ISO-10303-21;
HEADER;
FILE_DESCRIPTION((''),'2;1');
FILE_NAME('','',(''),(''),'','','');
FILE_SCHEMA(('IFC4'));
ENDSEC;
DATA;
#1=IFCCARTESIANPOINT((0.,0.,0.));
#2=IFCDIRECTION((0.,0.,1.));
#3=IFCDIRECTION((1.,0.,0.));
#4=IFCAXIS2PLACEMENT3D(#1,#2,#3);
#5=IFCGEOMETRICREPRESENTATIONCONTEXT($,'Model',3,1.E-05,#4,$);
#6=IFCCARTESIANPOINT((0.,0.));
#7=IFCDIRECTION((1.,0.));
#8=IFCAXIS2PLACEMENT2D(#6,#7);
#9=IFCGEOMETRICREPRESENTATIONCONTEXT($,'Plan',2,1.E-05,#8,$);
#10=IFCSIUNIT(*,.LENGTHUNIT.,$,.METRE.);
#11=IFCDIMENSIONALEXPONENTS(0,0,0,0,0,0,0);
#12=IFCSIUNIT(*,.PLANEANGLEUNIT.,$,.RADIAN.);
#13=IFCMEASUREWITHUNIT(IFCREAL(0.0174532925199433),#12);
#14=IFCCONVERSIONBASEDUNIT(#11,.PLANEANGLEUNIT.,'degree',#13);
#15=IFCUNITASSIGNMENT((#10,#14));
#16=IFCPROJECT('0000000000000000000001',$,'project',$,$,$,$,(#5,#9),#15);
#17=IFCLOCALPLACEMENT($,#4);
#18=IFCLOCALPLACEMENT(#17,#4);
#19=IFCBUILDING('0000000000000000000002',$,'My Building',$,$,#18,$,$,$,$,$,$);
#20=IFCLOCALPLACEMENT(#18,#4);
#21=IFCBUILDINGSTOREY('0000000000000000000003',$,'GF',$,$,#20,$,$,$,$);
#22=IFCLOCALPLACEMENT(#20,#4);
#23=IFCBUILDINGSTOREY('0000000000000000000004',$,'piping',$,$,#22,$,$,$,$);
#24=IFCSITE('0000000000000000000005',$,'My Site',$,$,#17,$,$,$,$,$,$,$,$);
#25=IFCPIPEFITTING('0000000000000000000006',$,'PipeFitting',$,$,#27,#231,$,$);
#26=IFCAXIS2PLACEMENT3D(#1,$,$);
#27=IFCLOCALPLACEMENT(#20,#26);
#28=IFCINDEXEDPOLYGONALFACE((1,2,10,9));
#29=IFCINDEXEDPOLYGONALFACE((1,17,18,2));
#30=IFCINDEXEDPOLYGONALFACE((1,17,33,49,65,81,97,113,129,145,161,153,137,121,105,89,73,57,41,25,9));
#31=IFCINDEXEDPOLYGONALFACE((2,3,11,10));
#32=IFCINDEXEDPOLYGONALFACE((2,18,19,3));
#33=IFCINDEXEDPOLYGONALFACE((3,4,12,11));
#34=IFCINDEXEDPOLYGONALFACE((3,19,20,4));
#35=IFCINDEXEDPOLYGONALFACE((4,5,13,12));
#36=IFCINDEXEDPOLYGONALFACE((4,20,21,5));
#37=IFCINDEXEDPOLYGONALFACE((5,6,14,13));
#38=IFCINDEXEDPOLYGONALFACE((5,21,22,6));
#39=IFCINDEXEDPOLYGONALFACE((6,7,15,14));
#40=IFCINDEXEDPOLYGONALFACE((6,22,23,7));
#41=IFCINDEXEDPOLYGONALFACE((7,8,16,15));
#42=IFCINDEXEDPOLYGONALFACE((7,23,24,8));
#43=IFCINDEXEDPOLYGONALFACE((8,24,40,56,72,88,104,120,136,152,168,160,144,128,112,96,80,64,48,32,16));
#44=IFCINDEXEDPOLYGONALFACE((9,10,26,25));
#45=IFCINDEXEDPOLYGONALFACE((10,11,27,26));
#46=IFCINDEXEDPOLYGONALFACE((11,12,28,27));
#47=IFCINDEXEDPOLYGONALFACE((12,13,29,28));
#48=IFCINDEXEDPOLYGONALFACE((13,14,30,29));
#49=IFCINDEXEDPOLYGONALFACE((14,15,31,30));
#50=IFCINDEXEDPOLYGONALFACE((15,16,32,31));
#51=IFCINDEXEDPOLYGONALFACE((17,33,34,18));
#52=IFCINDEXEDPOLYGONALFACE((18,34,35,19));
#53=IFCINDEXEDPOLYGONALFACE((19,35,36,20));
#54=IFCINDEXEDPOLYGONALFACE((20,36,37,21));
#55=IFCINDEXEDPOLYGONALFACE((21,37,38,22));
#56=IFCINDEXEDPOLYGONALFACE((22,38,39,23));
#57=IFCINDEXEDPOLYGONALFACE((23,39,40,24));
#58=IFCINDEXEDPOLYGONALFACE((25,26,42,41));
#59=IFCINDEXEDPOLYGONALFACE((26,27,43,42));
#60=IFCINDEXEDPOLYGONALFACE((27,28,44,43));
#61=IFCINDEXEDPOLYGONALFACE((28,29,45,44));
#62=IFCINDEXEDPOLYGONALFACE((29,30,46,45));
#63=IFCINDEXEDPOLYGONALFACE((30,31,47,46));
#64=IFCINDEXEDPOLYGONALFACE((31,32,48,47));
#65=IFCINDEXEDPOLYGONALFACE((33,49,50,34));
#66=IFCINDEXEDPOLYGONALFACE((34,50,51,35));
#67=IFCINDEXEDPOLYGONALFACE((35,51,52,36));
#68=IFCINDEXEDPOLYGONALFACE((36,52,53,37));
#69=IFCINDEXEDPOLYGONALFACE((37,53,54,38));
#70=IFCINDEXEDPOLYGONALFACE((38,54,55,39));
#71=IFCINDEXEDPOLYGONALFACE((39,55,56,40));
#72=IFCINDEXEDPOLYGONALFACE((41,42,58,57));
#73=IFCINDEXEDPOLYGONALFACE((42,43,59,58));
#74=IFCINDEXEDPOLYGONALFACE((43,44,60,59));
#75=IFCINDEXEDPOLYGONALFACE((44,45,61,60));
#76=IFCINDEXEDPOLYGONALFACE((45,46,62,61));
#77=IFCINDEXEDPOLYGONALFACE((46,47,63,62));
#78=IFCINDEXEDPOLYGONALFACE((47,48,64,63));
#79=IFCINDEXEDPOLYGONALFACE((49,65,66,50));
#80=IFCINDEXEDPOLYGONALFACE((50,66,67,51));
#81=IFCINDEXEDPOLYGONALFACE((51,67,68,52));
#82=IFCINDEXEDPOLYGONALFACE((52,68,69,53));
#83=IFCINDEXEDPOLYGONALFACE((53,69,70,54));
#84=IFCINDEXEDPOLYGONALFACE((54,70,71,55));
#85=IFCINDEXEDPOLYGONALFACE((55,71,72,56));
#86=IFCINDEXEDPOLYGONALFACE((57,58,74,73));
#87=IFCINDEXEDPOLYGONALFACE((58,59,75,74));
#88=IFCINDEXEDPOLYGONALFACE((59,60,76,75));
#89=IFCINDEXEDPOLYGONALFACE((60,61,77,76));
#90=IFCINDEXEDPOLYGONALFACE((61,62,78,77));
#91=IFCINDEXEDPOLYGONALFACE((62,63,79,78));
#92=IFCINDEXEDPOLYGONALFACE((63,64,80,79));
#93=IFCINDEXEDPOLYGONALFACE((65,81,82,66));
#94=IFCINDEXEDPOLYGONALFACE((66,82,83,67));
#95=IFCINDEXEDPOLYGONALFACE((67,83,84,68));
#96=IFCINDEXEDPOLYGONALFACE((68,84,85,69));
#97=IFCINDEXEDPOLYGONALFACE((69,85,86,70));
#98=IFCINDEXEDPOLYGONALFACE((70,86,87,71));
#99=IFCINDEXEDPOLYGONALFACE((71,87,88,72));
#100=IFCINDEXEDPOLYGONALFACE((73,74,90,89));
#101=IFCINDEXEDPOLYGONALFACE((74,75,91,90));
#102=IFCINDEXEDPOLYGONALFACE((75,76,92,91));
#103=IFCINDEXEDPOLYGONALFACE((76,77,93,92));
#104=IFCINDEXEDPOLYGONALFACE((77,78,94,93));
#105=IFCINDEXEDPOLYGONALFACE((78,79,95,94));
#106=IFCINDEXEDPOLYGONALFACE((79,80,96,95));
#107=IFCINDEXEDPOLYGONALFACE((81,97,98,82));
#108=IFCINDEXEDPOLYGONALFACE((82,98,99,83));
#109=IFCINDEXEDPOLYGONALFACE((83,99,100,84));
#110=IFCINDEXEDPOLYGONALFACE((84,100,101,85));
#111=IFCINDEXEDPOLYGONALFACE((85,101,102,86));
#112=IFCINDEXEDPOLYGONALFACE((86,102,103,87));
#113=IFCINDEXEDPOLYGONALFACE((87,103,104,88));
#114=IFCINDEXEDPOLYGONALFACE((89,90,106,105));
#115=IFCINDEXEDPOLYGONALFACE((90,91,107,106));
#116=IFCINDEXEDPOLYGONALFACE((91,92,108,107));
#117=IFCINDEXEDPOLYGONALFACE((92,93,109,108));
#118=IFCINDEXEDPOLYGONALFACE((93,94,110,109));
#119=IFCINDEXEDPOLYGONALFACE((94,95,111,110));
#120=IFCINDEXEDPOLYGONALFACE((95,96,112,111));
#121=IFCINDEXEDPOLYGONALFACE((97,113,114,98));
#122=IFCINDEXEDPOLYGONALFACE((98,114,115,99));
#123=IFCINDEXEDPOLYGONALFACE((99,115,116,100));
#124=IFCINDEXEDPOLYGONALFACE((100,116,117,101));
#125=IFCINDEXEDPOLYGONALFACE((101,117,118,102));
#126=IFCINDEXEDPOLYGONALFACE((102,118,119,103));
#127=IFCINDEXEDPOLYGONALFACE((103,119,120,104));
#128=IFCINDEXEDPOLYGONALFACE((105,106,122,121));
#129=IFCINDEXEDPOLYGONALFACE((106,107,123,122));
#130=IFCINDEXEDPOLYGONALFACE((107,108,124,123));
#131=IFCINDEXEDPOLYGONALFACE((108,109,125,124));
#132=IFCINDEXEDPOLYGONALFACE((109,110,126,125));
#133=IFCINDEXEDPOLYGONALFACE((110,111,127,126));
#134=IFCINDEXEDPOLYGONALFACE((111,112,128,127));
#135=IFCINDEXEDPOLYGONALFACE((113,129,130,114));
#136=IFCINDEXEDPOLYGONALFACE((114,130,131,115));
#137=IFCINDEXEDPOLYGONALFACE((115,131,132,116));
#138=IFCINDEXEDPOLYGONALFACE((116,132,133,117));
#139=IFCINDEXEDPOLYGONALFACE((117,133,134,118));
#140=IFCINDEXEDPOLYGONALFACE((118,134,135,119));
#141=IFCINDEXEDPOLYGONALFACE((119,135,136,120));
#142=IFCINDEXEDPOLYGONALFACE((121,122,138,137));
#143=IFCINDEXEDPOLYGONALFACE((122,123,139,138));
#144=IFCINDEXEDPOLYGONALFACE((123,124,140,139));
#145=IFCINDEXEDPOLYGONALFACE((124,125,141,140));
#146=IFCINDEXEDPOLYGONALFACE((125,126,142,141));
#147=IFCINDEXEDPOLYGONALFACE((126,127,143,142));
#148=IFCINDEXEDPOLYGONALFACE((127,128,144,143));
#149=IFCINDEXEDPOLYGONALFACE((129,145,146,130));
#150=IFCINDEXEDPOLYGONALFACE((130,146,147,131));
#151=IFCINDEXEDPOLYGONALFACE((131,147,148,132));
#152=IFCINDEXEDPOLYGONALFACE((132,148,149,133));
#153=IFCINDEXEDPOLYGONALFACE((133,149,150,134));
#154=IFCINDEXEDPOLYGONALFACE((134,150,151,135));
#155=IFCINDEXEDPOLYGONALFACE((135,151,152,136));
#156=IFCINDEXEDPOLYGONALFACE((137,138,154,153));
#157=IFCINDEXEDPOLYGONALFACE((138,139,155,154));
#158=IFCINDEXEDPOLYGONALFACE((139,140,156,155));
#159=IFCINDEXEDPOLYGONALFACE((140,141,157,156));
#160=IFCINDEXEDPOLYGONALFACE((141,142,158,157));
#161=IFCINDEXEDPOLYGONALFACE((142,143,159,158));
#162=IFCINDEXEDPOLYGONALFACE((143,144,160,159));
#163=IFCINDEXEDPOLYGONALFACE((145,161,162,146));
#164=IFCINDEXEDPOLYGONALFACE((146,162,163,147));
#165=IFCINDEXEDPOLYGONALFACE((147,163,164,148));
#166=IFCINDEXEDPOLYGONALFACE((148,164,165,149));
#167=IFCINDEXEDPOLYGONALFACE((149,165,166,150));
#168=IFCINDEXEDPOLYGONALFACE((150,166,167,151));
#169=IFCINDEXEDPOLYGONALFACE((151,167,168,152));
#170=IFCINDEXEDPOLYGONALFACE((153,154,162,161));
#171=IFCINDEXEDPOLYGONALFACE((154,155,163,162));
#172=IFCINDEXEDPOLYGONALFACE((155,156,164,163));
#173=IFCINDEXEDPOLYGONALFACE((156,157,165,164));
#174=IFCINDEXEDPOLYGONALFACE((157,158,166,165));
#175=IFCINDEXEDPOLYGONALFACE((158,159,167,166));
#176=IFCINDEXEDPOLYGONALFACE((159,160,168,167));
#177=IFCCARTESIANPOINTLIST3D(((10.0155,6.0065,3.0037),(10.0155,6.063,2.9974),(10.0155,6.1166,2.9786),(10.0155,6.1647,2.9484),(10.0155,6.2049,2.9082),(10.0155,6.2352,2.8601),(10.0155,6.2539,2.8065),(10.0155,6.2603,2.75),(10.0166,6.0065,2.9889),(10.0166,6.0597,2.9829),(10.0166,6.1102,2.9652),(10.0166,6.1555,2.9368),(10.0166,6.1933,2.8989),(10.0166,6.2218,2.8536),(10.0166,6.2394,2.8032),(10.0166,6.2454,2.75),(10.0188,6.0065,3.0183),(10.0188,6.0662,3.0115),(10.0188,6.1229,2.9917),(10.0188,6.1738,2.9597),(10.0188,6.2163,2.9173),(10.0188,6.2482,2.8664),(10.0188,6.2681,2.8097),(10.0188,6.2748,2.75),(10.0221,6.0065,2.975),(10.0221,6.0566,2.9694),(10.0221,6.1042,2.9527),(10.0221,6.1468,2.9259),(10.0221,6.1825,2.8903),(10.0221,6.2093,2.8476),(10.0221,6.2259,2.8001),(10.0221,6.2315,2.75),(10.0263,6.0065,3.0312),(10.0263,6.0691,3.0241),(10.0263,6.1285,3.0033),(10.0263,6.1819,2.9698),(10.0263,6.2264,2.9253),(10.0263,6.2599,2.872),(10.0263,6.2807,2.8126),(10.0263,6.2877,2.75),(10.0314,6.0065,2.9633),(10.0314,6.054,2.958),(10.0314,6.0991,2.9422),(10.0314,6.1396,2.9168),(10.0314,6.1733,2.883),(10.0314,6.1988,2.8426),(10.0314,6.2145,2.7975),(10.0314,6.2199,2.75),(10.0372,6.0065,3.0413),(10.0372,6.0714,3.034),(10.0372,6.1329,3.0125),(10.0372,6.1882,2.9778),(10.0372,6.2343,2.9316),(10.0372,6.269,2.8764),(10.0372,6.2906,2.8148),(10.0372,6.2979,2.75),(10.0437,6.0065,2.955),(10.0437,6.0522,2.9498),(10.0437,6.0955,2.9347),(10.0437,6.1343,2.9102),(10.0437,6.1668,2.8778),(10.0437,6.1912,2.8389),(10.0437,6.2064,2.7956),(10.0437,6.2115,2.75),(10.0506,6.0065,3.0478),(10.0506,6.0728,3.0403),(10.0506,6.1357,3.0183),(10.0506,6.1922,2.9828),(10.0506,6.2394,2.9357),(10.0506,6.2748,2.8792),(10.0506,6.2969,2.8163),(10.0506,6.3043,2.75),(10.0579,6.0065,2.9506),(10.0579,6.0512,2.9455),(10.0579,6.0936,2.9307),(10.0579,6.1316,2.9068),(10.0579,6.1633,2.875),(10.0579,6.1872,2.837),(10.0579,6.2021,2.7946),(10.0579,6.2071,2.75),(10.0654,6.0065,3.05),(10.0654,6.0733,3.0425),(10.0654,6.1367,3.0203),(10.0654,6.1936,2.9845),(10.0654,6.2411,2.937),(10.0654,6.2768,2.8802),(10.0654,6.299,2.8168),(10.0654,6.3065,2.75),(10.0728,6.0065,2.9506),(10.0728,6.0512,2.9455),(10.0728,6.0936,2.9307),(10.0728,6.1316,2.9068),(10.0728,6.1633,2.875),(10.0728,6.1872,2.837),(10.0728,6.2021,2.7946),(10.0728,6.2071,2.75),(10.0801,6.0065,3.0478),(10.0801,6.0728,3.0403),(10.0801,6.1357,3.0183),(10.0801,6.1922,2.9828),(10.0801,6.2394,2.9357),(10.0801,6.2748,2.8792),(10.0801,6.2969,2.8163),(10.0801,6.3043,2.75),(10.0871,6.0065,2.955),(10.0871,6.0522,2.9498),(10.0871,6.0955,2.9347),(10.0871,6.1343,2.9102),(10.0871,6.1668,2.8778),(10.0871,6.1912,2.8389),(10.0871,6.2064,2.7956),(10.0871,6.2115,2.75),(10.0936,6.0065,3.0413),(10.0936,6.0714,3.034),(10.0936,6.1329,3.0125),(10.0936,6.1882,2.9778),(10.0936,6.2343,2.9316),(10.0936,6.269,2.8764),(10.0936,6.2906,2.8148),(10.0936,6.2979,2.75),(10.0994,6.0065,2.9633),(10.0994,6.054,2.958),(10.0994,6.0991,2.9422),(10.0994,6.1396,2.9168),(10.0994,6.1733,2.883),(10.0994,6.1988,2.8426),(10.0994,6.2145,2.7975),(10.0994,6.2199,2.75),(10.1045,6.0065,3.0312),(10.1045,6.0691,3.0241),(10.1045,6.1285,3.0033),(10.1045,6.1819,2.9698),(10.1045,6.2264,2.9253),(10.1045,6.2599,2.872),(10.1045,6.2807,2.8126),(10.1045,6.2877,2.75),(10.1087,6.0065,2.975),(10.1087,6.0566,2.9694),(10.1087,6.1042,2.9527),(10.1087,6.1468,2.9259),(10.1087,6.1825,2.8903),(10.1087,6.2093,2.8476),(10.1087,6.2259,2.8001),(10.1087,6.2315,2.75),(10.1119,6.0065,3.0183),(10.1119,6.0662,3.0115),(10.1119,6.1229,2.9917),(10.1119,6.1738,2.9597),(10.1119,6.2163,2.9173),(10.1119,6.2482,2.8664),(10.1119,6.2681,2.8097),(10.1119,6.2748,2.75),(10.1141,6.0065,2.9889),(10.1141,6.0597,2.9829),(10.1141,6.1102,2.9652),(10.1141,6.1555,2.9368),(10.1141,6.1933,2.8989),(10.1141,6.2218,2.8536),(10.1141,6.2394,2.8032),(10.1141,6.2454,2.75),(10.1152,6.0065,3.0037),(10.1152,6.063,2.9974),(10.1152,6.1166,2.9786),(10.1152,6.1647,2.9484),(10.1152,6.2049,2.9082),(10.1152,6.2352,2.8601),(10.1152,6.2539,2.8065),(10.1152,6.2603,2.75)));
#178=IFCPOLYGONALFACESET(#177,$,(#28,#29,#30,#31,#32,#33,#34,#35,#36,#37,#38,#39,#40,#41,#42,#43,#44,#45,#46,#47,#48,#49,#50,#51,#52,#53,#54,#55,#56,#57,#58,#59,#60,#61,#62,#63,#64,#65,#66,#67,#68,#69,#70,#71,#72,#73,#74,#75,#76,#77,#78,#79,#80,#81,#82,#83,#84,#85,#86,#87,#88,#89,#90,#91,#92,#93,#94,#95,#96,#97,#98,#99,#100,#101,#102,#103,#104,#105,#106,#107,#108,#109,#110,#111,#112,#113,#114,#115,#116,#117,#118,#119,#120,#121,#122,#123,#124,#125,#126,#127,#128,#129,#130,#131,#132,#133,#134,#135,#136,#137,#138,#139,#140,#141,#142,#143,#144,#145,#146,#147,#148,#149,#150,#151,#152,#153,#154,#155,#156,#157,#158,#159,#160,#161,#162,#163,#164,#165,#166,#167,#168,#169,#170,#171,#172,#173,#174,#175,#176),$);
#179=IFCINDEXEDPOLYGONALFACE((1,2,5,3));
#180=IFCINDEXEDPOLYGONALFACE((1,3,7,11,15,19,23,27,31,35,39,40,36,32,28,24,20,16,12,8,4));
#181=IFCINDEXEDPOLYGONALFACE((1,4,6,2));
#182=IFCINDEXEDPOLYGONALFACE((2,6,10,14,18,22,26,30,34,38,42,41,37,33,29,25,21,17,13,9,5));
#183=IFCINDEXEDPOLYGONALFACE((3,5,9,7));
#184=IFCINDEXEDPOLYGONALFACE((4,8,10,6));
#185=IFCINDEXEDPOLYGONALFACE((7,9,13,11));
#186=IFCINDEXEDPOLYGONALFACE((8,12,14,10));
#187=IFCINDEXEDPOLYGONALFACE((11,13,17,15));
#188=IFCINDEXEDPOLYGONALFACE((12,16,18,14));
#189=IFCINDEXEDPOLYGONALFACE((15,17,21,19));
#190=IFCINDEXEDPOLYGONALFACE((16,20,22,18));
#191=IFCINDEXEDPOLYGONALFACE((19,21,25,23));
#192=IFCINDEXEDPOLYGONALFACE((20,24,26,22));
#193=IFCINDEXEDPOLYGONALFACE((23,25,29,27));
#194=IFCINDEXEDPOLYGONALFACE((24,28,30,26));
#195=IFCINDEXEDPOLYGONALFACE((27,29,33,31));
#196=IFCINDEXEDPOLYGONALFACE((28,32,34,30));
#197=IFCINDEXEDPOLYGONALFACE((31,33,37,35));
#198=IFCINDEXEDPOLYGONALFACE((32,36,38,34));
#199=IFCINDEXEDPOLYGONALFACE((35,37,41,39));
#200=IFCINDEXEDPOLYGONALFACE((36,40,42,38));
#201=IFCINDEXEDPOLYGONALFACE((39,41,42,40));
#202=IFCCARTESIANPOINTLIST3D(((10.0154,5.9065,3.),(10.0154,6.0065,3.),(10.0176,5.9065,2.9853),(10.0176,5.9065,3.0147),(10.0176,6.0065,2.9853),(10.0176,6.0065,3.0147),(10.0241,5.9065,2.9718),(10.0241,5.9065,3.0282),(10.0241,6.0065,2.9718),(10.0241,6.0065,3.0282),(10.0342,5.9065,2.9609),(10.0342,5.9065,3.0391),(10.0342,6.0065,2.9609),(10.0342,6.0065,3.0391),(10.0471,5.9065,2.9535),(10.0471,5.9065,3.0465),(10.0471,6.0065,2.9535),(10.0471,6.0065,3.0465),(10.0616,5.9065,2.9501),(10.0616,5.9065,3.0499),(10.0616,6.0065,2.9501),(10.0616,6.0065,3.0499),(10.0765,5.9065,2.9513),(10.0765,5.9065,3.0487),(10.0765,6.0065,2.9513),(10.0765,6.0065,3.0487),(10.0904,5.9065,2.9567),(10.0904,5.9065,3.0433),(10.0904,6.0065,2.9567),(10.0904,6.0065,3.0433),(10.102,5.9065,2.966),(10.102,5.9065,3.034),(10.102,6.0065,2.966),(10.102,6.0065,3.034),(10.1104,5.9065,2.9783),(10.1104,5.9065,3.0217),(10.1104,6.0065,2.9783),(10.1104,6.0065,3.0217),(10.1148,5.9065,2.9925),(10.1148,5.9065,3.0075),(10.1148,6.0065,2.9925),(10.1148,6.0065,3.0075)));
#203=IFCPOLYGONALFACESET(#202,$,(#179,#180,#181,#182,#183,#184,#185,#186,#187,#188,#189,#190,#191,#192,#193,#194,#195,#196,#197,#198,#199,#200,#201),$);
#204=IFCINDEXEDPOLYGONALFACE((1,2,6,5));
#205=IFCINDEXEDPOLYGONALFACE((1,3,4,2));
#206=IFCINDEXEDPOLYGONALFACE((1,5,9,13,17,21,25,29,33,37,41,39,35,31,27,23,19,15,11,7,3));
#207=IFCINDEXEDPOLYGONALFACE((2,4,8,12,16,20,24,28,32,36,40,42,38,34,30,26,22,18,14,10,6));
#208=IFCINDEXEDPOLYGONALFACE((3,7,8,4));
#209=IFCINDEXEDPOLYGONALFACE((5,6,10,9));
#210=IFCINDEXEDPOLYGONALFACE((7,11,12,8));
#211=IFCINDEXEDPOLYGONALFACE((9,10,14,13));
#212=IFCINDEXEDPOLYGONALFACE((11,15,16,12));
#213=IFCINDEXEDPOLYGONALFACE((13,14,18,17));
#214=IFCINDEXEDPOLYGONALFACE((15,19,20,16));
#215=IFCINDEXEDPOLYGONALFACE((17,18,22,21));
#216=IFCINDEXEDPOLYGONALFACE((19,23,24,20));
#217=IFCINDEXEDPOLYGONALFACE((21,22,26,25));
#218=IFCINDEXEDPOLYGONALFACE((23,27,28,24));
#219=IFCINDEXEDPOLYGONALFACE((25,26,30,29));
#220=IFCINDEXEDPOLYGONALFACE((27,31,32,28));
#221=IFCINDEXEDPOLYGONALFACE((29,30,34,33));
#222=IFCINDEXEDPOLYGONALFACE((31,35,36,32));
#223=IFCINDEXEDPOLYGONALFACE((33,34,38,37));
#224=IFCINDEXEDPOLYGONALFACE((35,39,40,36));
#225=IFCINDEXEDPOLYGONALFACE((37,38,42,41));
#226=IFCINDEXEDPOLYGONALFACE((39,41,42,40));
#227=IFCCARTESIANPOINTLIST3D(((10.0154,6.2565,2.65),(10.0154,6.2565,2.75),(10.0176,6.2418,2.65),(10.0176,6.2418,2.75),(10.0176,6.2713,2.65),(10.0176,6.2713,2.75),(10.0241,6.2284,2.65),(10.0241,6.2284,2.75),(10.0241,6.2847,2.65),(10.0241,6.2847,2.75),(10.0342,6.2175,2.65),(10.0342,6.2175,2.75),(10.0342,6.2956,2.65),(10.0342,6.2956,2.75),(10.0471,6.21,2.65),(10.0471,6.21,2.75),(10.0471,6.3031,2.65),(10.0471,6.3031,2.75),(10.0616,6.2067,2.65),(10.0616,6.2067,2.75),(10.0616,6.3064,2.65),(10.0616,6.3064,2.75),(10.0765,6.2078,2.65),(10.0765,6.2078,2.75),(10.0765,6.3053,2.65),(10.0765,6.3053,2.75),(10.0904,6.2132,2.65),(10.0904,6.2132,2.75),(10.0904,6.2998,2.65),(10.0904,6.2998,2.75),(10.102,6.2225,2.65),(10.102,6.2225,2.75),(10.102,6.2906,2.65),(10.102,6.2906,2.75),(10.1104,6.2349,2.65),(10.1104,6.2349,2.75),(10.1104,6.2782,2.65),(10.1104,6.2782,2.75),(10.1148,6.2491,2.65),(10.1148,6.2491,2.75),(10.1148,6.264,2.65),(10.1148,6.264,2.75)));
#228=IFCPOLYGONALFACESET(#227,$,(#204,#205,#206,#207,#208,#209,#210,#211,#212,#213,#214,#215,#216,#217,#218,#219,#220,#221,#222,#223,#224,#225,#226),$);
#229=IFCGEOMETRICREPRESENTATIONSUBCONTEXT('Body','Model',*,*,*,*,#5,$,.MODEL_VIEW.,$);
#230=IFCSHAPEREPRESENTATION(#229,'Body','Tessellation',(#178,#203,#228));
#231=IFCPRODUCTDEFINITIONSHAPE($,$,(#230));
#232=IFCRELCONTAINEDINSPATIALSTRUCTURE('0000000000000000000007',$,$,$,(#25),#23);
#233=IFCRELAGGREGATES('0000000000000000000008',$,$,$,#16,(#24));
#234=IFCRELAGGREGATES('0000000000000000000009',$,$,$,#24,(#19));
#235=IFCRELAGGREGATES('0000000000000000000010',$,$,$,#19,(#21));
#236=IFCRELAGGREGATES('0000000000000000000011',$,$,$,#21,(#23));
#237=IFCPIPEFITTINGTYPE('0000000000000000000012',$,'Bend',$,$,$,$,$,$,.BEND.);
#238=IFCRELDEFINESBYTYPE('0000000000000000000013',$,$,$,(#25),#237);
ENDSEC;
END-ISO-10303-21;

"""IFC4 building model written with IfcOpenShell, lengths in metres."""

from ifc_helpers import new_model, entity, si_unit, converted_unit, frame, origin_with_axes, origin_2d_with_axis, place, context, subcontext, project, spatial, circle, extrude, source, transform, mapped, type_object, type_shapes, element, save


model = new_model("IFC4")

# Units and contexts
model_context = context("Model", 3, precision=1e-05, world=origin_with_axes())
plan_context = context("Plan", 2, precision=1e-05, world=origin_2d_with_axis())
body_context = subcontext(model_context, "Body", "Model", "MODEL_VIEW")
ifc_project = project(units=[si_unit("LENGTHUNIT", "METRE"), converted_unit("PLANEANGLEUNIT", "degree", entity("IfcReal", 0.0174532925199433), si_unit("PLANEANGLEUNIT", "RADIAN"), dimensions=[0, 0, 0, 0, 0, 0, 0])], contexts=[model_context, plan_context])

# Site, building, storeys
site_placement = place(None, origin_with_axes())
site = spatial("IfcSite", under=ifc_project, at=site_placement, Name="My Site")
building_placement = place(site_placement, origin_with_axes())
building = spatial("IfcBuilding", under=site, at=building_placement, Name="My Building")
storey_1_placement = place(building_placement, origin_with_axes())
storey_1 = spatial("IfcBuildingStorey", under=building, at=storey_1_placement, Name="GF")
storey_2_placement = place(storey_1_placement, origin_with_axes())
storey_2 = spatial("IfcBuildingStorey", under=storey_1, at=storey_2_placement, Name="piping")

# Pipe fitting
pipe_fitting_type = type_object("IfcPipeFittingType", Name="Bend", PredefinedType="BEND")
shared_shape = source(origin_with_axes(), body_context, "Body", "SolidModel", [
    entity("IfcSweptDiskSolid", entity("IfcIndexedPolyCurve", entity("IfcCartesianPointList3D", [[0.0, 0.0, 0.1], [0.0, -0.0732, 0.2768], [0.0, -0.25, 0.35]]), [entity("IfcArcIndex", [1, 2, 3])]), 0.05),
    extrude(circle(Radius=0.05), origin_with_axes(), (0.0, 0.0, 1.0), 0.1),
    extrude(circle(Radius=0.05), frame((0.0, -0.25, 0.35), z_axis=(0.0, -1.0, 0.0), x_axis=(1.0, 0.0, 0.0)), (0.0, 0.0, 1.0), 0.1),
])
type_shapes(pipe_fitting_type, [shared_shape])
for number, where, z_axis, x_axis, name in (
    (1, (10.0654, 5.9065, 3.0), (0.0, 1.0, 0.0), (-1.0, 0.0, 0.0), "PipeFitting"),
):
    element("IfcPipeFitting", number, at=place(storey_2_placement, frame(where, z_axis=z_axis, x_axis=x_axis)), inside=storey_2, type_object=pipe_fitting_type, Name=name, context=body_context, shape_type="MappedRepresentation", body=[
        mapped(shared_shape, transform((0.0, 0.0, 0.0), x_axis=(1.0, 0.0, 0.0), y_axis=(0.0, 1.0, 0.0), z_axis=(0.0, 0.0, 1.0), scale=1.0)),
    ])

save(model, "model.ifc")
